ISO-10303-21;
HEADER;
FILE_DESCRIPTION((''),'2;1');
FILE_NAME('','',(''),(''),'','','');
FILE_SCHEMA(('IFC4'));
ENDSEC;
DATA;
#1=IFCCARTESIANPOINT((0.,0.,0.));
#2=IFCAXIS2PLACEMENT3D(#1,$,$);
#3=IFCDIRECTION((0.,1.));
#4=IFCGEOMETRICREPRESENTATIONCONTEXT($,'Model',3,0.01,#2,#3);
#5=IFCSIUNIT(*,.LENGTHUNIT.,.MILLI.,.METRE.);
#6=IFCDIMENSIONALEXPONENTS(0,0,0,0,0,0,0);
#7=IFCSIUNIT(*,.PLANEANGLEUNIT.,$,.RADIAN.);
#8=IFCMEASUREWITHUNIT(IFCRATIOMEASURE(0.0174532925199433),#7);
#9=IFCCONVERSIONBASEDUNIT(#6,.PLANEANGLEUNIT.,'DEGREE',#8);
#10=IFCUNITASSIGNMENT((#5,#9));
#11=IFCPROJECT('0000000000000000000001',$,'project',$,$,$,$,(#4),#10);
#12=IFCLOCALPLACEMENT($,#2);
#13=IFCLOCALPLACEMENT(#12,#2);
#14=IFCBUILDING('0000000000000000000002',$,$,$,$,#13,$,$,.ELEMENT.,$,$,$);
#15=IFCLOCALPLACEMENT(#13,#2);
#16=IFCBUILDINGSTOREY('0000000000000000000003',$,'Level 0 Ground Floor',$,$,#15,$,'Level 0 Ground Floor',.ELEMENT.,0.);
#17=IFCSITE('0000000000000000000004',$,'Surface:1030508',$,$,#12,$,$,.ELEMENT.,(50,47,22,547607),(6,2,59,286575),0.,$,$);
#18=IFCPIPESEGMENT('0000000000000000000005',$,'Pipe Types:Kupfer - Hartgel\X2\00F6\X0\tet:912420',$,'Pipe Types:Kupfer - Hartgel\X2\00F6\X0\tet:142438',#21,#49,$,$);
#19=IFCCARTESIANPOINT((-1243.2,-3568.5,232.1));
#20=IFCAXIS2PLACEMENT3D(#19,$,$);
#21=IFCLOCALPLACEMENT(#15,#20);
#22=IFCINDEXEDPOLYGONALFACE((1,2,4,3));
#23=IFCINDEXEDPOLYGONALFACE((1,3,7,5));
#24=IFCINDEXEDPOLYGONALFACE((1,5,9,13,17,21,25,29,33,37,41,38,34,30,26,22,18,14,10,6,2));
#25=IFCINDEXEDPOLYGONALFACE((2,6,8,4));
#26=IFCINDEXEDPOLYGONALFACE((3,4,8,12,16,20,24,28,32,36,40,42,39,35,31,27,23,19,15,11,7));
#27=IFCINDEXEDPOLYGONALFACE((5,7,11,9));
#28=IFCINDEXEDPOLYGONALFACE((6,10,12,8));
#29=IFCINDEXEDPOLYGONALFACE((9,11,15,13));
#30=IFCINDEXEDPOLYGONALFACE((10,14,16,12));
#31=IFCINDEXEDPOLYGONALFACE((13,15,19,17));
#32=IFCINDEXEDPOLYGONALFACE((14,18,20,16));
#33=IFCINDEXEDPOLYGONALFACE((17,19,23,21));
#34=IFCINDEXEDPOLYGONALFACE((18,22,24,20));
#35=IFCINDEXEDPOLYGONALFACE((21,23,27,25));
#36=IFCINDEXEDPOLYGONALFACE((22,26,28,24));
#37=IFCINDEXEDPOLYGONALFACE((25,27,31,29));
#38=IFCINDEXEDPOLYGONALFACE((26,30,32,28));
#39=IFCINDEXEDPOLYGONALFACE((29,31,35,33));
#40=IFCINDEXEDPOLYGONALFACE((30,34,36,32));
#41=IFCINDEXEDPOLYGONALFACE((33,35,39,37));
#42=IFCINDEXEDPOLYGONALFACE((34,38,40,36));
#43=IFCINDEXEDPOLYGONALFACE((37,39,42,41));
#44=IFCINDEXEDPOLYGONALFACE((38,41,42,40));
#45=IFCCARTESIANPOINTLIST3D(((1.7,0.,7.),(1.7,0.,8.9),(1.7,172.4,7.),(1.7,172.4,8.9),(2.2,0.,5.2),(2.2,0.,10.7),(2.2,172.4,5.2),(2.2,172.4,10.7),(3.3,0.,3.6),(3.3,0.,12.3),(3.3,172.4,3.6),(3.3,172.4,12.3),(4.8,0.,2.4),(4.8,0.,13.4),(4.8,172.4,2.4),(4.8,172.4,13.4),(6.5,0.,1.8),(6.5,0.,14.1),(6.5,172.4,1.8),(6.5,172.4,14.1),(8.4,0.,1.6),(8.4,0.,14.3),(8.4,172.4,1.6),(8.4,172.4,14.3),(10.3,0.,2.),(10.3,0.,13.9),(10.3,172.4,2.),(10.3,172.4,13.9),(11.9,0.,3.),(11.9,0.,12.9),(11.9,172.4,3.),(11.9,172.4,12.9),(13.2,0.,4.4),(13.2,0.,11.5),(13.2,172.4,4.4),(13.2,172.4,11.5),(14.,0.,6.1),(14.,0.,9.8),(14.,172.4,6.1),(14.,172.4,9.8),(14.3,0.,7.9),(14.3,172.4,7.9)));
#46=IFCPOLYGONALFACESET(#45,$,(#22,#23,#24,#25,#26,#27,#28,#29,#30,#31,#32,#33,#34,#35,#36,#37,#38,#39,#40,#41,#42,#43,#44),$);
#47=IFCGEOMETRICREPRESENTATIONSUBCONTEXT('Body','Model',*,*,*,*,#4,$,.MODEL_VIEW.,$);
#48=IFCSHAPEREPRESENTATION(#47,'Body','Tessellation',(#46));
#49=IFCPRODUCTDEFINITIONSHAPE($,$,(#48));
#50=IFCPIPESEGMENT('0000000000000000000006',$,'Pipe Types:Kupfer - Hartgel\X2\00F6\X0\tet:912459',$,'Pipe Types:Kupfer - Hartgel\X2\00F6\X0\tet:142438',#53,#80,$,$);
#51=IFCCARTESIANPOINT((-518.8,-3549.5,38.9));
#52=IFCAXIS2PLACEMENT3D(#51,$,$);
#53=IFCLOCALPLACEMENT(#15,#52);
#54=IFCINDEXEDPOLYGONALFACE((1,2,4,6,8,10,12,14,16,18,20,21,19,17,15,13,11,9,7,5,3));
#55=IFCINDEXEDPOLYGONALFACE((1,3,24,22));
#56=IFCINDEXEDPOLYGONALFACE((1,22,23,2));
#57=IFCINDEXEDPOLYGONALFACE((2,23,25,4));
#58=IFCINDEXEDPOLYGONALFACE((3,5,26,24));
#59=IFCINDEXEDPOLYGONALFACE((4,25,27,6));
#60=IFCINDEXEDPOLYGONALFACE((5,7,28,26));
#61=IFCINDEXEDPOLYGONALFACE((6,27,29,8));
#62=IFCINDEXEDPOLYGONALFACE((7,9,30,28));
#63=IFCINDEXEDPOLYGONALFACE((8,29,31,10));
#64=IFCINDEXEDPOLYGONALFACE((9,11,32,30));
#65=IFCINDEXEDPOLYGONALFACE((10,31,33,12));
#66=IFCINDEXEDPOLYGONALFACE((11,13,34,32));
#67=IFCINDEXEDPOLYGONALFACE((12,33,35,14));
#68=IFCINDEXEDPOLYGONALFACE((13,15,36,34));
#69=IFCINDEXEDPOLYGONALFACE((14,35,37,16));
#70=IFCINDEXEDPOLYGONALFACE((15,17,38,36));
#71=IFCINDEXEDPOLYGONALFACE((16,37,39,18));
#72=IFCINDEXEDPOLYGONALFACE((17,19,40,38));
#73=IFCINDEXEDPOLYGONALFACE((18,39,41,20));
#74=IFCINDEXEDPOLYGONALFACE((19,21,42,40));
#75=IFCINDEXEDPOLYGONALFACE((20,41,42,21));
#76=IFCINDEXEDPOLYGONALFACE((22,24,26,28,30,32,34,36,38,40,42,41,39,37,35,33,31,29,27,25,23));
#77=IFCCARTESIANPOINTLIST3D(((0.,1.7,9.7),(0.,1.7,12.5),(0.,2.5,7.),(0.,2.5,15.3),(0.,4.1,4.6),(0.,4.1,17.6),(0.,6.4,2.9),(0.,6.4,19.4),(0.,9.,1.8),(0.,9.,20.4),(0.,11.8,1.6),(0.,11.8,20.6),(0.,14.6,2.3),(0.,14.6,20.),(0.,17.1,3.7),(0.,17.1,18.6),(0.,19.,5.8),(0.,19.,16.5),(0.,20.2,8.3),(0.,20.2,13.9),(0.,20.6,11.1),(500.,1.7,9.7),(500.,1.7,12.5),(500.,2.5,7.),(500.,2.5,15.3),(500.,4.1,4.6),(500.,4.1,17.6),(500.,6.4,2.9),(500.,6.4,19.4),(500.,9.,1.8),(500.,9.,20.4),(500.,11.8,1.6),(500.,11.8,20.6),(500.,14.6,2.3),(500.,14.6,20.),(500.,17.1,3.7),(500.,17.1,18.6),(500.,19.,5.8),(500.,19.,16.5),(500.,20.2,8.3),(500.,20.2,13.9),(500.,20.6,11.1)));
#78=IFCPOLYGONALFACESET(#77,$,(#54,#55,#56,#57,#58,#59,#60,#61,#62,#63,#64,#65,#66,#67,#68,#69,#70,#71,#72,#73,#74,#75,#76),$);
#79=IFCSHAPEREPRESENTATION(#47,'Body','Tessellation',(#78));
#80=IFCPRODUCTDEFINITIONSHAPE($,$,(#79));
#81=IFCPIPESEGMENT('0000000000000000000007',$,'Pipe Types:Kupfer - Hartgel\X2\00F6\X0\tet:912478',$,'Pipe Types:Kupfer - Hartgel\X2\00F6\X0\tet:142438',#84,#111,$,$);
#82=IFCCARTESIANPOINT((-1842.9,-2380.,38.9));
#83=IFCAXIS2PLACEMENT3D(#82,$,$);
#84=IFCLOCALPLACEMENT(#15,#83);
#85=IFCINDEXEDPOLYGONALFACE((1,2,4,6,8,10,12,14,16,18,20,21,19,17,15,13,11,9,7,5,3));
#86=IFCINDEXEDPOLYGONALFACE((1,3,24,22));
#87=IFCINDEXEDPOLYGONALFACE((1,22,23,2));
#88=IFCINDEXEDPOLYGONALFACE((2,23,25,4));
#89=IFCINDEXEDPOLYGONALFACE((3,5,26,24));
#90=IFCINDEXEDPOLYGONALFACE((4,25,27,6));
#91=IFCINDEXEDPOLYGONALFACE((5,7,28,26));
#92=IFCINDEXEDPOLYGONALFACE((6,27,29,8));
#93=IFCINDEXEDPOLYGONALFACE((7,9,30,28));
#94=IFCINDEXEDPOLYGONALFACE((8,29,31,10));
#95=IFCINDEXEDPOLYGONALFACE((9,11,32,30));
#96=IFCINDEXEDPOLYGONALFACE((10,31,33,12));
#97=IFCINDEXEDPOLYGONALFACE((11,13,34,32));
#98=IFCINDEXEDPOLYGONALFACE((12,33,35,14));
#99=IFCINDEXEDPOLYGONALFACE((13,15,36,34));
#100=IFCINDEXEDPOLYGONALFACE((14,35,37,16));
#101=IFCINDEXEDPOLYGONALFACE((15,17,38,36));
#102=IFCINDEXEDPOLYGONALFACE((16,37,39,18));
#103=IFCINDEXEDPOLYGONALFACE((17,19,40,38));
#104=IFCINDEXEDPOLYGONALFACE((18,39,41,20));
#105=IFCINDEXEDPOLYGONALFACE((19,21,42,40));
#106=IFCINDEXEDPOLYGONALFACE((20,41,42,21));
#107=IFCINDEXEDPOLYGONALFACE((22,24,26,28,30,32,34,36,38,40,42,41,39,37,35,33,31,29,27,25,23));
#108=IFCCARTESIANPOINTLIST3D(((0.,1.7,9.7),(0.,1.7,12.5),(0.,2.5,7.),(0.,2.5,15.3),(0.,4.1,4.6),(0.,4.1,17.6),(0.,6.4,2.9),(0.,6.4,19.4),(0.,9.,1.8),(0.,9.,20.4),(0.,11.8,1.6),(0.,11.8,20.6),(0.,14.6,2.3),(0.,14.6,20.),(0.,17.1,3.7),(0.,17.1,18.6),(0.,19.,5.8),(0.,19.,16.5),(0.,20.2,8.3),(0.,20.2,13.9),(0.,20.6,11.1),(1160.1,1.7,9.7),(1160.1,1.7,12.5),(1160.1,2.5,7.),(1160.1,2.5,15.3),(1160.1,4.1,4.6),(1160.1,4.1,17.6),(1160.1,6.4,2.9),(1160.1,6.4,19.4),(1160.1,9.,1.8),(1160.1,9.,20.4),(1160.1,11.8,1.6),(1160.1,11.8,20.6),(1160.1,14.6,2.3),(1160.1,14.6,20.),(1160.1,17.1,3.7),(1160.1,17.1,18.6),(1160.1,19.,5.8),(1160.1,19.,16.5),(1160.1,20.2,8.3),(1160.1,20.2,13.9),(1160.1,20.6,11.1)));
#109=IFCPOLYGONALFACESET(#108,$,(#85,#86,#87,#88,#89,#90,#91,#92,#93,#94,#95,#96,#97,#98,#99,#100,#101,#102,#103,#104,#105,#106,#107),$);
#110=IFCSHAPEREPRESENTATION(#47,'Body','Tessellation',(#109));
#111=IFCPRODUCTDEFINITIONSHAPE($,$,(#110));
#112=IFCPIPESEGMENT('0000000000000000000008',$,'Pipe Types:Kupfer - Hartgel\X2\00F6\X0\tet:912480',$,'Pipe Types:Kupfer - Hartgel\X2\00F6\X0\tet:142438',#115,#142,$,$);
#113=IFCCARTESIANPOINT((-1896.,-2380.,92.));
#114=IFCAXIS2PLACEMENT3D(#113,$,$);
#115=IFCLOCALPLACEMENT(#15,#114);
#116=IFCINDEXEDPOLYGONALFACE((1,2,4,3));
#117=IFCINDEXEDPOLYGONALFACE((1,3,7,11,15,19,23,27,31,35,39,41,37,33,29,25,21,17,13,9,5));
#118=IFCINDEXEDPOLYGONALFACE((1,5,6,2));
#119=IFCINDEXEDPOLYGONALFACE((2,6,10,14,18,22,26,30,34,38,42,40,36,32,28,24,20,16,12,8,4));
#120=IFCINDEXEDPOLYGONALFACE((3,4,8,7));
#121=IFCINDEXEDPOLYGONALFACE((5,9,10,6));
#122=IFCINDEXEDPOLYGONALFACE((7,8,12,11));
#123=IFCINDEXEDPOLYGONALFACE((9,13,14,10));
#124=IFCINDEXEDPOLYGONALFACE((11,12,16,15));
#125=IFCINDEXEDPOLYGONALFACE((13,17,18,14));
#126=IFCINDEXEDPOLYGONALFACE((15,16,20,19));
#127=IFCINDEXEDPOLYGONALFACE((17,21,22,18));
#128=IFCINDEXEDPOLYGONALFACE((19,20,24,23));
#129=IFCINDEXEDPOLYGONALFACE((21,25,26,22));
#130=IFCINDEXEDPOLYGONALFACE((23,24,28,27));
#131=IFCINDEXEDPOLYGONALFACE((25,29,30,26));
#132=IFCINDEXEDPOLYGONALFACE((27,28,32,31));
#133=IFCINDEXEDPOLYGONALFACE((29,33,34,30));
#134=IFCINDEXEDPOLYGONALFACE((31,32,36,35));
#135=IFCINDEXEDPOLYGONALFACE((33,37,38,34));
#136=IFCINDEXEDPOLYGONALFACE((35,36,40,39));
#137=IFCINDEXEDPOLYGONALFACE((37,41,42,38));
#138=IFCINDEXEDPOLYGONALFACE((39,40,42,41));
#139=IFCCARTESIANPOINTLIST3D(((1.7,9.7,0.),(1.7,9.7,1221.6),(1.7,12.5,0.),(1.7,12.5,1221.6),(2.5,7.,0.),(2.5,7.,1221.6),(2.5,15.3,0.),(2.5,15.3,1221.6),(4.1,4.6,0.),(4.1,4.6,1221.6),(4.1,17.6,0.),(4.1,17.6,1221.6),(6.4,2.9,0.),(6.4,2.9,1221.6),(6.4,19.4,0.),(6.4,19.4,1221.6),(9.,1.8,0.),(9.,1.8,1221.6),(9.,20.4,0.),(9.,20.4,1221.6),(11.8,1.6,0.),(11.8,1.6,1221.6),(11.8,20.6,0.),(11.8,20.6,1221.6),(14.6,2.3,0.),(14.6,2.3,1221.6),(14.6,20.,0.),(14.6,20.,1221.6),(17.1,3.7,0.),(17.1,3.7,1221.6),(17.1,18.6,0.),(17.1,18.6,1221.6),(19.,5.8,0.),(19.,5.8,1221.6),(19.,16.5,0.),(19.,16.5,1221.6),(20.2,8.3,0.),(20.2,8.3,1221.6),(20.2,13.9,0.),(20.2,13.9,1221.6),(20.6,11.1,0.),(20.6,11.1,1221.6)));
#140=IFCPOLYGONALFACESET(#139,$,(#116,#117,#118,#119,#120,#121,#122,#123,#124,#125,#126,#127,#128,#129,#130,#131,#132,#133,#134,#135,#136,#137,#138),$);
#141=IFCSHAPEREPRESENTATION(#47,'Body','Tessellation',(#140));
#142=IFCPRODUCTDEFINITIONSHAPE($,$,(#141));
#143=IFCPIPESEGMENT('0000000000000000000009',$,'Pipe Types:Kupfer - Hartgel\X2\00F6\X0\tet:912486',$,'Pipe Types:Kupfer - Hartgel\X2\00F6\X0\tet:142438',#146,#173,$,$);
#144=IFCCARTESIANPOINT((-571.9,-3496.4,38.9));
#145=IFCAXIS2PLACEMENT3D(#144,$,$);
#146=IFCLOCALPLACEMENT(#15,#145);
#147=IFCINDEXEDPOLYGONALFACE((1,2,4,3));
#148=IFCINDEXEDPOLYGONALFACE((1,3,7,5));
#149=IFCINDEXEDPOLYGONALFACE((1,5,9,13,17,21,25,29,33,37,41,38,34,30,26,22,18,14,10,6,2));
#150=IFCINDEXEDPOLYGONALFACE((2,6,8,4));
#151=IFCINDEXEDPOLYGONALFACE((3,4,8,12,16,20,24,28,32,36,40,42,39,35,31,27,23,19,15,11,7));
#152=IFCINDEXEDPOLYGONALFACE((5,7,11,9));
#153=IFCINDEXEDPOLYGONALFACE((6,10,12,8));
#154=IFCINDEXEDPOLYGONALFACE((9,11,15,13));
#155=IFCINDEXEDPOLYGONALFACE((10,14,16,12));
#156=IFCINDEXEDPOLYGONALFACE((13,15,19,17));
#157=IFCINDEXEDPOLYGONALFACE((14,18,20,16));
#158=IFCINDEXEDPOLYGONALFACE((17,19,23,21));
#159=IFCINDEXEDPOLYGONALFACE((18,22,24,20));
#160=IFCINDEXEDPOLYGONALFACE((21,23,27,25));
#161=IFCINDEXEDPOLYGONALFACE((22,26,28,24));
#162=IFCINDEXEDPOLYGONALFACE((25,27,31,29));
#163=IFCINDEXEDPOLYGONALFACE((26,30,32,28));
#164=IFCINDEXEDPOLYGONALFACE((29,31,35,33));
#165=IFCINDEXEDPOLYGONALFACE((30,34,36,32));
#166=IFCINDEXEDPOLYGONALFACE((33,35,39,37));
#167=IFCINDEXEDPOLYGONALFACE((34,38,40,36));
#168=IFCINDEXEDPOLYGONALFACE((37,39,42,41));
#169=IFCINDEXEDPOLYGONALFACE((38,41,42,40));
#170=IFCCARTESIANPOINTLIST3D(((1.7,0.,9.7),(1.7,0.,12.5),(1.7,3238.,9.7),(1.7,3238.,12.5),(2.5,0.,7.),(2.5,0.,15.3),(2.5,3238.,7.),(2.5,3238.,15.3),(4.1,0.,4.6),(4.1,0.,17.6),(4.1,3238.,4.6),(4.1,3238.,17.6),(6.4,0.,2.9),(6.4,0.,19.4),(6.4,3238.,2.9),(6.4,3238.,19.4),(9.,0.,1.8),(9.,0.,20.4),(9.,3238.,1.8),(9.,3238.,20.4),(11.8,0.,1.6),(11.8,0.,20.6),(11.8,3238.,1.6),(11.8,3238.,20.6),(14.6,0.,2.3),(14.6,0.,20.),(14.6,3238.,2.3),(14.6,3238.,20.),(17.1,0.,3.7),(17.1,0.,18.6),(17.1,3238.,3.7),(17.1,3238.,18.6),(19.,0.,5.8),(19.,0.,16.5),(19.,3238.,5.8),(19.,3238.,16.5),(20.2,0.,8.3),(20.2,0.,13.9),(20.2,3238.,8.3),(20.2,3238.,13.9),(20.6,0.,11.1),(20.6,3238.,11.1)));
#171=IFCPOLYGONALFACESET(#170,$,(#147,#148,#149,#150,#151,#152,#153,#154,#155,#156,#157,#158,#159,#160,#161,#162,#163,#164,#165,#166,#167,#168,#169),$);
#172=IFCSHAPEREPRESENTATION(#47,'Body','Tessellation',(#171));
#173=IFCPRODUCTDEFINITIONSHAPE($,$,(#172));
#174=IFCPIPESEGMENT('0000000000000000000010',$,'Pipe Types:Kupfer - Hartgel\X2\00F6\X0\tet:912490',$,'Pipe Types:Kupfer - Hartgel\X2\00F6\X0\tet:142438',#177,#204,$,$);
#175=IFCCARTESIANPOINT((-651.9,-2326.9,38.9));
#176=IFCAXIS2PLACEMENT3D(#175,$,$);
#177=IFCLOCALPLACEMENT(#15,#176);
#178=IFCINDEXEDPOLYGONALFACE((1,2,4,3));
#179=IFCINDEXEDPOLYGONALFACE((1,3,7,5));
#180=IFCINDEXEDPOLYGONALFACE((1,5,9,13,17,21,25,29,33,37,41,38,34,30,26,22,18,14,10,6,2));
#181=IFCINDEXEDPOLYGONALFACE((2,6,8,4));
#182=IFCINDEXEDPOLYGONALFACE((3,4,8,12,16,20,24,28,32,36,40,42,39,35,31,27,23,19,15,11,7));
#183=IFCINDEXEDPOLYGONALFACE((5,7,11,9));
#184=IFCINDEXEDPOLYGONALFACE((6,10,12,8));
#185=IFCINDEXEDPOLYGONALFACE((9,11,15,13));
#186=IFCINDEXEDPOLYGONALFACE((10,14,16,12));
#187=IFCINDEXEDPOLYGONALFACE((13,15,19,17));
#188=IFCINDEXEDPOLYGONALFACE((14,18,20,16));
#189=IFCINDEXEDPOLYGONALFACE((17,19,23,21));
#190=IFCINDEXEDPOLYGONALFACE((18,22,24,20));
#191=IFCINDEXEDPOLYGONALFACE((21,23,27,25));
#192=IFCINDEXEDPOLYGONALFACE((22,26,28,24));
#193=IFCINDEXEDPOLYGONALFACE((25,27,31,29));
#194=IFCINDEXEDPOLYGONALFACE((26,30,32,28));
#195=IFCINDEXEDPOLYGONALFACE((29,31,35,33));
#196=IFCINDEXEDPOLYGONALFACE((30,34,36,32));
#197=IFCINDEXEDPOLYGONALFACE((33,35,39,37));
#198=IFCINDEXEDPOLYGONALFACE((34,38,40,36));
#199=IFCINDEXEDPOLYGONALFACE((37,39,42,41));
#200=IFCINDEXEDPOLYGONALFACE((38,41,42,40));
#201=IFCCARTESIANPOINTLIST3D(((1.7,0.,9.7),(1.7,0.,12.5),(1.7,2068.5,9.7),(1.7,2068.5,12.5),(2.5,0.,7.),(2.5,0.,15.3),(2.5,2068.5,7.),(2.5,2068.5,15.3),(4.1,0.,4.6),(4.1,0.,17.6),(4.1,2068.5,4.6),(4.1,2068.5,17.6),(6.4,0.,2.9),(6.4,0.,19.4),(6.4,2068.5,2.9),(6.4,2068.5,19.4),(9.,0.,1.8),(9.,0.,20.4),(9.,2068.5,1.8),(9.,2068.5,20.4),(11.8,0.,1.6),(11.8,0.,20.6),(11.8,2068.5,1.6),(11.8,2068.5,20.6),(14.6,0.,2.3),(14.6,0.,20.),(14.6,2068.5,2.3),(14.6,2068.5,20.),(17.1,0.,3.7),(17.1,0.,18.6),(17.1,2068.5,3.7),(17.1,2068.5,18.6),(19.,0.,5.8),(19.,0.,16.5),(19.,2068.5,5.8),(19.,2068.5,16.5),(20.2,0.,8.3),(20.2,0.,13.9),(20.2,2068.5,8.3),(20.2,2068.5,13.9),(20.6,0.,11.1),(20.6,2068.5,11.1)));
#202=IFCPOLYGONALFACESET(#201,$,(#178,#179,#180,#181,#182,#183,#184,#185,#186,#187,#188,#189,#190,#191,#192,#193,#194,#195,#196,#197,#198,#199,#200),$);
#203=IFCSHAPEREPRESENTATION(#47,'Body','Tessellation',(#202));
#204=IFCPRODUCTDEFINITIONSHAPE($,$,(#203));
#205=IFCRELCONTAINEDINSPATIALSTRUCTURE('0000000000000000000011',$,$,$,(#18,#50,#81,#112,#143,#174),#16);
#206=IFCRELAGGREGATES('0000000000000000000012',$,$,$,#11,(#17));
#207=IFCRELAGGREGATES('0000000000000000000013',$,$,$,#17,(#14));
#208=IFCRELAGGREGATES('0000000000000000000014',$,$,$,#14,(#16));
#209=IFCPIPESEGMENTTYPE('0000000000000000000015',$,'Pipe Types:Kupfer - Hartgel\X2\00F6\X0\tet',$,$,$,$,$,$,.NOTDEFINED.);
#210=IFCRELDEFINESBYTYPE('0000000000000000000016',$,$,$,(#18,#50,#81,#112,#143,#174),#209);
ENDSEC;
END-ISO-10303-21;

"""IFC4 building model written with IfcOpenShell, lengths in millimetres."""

from ifc_helpers import new_model, entity, si_unit, converted_unit, direction, frame, frame_2d, origin, origin_2d_with_axis, place, context, subcontext, project, spatial, circle, extrude, type_object, element, save


model = new_model("IFC4")

# Units and contexts
model_context = context("Model", 3, precision=0.01, world=origin(), true_north=direction((0.0, 1.0)))
body_context = subcontext(model_context, "Body", "Model", "MODEL_VIEW")
ifc_project = project(units=[si_unit("LENGTHUNIT", "METRE", prefix="MILLI"), converted_unit("PLANEANGLEUNIT", "DEGREE", entity("IfcRatioMeasure", 0.0174532925199433), si_unit("PLANEANGLEUNIT", "RADIAN"), dimensions=[0, 0, 0, 0, 0, 0, 0])], contexts=[model_context])

# Site, building, storey
site_placement = place(None, origin())
site = spatial("IfcSite", under=ifc_project, at=site_placement, Name="Surface:1030508", CompositionType="ELEMENT", RefLatitude=(50, 47, 22, 547607), RefLongitude=(6, 2, 59, 286575), RefElevation=0.0)
building_placement = place(site_placement, origin())
building = spatial("IfcBuilding", under=site, at=building_placement, CompositionType="ELEMENT")
storey_placement = place(building_placement, origin())
storey = spatial("IfcBuildingStorey", under=building, at=storey_placement, Name="Level 0 Ground Floor", LongName="Level 0 Ground Floor", CompositionType="ELEMENT", Elevation=0.0)

# Pipe segments
pipe_segment_type = type_object("IfcPipeSegmentType", Name="Pipe Types:Kupfer - Hartgelötet", PredefinedType="NOTDEFINED")
pipe_segment_1_placement = place(storey_placement, frame((-1243.2, -3568.5, 232.1)))
element("IfcPipeSegment", 1, at=pipe_segment_1_placement, inside=storey, type_object=pipe_segment_type, Name="Pipe Types:Kupfer - Hartgelötet:912420", ObjectType="Pipe Types:Kupfer - Hartgelötet:142438", context=body_context, shape_type="SweptSolid", body=[
    extrude(circle(Radius=6.3, at=frame_2d((0.0, 0.0), x_axis=(1.0, 0.0))), frame((7.9, 0.0, 7.9), z_axis=(0.0, 1.0, 0.0), x_axis=(1.0, 0.0, 0.0)), (0.0, 0.0, 1.0), 172.4),
])
pipe_segment_2_placement = place(storey_placement, frame((-518.8, -3549.5, 38.9)))
element("IfcPipeSegment", 2, at=pipe_segment_2_placement, inside=storey, type_object=pipe_segment_type, Name="Pipe Types:Kupfer - Hartgelötet:912459", ObjectType="Pipe Types:Kupfer - Hartgelötet:142438", context=body_context, shape_type="SweptSolid", body=[
    extrude(circle(Radius=9.5, at=frame_2d((0.0, 0.0), x_axis=(1.0, 0.0))), frame((0.0, 11.1, 11.1), z_axis=(1.0, 0.0, 0.0), x_axis=(0.0, 1.0, 0.0)), (0.0, 0.0, 1.0), 500.0),
])
pipe_segment_3_placement = place(storey_placement, frame((-1842.9, -2380.0, 38.9)))
element("IfcPipeSegment", 3, at=pipe_segment_3_placement, inside=storey, type_object=pipe_segment_type, Name="Pipe Types:Kupfer - Hartgelötet:912478", ObjectType="Pipe Types:Kupfer - Hartgelötet:142438", context=body_context, shape_type="SweptSolid", body=[
    extrude(circle(Radius=9.5, at=frame_2d((0.0, 0.0), x_axis=(1.0, 0.0))), frame((0.0, 11.1, 11.1), z_axis=(1.0, 0.0, 0.0), x_axis=(0.0, 1.0, 0.0)), (0.0, 0.0, 1.0), 1160.1),
])
pipe_segment_4_placement = place(storey_placement, frame((-1896.0, -2380.0, 92.0)))
element("IfcPipeSegment", 4, at=pipe_segment_4_placement, inside=storey, type_object=pipe_segment_type, Name="Pipe Types:Kupfer - Hartgelötet:912480", ObjectType="Pipe Types:Kupfer - Hartgelötet:142438", context=body_context, shape_type="SweptSolid", body=[
    extrude(circle(Radius=9.5, at=origin_2d_with_axis()), frame((11.1, 11.1, 0.0)), (0.0, 0.0, 1.0), 1221.6),
])
pipe_segment_5_placement = place(storey_placement, frame((-571.9, -3496.4, 38.9)))
element("IfcPipeSegment", 5, at=pipe_segment_5_placement, inside=storey, type_object=pipe_segment_type, Name="Pipe Types:Kupfer - Hartgelötet:912486", ObjectType="Pipe Types:Kupfer - Hartgelötet:142438", context=body_context, shape_type="SweptSolid", body=[
    extrude(circle(Radius=9.5, at=frame_2d((0.0, 0.0), x_axis=(1.0, 0.0))), frame((11.1, 0.0, 11.1), z_axis=(0.0, 1.0, 0.0), x_axis=(1.0, 0.0, 0.0)), (0.0, 0.0, 1.0), 3238.0),
])
pipe_segment_6_placement = place(storey_placement, frame((-651.9, -2326.9, 38.9)))
element("IfcPipeSegment", 6, at=pipe_segment_6_placement, inside=storey, type_object=pipe_segment_type, Name="Pipe Types:Kupfer - Hartgelötet:912490", ObjectType="Pipe Types:Kupfer - Hartgelötet:142438", context=body_context, shape_type="SweptSolid", body=[
    extrude(circle(Radius=9.5, at=frame_2d((0.0, 0.0), x_axis=(1.0, 0.0))), frame((11.1, 0.0, 11.1), z_axis=(0.0, 1.0, 0.0), x_axis=(1.0, 0.0, 0.0)), (0.0, 0.0, 1.0), 2068.5),
])

save(model, "model.ifc")
